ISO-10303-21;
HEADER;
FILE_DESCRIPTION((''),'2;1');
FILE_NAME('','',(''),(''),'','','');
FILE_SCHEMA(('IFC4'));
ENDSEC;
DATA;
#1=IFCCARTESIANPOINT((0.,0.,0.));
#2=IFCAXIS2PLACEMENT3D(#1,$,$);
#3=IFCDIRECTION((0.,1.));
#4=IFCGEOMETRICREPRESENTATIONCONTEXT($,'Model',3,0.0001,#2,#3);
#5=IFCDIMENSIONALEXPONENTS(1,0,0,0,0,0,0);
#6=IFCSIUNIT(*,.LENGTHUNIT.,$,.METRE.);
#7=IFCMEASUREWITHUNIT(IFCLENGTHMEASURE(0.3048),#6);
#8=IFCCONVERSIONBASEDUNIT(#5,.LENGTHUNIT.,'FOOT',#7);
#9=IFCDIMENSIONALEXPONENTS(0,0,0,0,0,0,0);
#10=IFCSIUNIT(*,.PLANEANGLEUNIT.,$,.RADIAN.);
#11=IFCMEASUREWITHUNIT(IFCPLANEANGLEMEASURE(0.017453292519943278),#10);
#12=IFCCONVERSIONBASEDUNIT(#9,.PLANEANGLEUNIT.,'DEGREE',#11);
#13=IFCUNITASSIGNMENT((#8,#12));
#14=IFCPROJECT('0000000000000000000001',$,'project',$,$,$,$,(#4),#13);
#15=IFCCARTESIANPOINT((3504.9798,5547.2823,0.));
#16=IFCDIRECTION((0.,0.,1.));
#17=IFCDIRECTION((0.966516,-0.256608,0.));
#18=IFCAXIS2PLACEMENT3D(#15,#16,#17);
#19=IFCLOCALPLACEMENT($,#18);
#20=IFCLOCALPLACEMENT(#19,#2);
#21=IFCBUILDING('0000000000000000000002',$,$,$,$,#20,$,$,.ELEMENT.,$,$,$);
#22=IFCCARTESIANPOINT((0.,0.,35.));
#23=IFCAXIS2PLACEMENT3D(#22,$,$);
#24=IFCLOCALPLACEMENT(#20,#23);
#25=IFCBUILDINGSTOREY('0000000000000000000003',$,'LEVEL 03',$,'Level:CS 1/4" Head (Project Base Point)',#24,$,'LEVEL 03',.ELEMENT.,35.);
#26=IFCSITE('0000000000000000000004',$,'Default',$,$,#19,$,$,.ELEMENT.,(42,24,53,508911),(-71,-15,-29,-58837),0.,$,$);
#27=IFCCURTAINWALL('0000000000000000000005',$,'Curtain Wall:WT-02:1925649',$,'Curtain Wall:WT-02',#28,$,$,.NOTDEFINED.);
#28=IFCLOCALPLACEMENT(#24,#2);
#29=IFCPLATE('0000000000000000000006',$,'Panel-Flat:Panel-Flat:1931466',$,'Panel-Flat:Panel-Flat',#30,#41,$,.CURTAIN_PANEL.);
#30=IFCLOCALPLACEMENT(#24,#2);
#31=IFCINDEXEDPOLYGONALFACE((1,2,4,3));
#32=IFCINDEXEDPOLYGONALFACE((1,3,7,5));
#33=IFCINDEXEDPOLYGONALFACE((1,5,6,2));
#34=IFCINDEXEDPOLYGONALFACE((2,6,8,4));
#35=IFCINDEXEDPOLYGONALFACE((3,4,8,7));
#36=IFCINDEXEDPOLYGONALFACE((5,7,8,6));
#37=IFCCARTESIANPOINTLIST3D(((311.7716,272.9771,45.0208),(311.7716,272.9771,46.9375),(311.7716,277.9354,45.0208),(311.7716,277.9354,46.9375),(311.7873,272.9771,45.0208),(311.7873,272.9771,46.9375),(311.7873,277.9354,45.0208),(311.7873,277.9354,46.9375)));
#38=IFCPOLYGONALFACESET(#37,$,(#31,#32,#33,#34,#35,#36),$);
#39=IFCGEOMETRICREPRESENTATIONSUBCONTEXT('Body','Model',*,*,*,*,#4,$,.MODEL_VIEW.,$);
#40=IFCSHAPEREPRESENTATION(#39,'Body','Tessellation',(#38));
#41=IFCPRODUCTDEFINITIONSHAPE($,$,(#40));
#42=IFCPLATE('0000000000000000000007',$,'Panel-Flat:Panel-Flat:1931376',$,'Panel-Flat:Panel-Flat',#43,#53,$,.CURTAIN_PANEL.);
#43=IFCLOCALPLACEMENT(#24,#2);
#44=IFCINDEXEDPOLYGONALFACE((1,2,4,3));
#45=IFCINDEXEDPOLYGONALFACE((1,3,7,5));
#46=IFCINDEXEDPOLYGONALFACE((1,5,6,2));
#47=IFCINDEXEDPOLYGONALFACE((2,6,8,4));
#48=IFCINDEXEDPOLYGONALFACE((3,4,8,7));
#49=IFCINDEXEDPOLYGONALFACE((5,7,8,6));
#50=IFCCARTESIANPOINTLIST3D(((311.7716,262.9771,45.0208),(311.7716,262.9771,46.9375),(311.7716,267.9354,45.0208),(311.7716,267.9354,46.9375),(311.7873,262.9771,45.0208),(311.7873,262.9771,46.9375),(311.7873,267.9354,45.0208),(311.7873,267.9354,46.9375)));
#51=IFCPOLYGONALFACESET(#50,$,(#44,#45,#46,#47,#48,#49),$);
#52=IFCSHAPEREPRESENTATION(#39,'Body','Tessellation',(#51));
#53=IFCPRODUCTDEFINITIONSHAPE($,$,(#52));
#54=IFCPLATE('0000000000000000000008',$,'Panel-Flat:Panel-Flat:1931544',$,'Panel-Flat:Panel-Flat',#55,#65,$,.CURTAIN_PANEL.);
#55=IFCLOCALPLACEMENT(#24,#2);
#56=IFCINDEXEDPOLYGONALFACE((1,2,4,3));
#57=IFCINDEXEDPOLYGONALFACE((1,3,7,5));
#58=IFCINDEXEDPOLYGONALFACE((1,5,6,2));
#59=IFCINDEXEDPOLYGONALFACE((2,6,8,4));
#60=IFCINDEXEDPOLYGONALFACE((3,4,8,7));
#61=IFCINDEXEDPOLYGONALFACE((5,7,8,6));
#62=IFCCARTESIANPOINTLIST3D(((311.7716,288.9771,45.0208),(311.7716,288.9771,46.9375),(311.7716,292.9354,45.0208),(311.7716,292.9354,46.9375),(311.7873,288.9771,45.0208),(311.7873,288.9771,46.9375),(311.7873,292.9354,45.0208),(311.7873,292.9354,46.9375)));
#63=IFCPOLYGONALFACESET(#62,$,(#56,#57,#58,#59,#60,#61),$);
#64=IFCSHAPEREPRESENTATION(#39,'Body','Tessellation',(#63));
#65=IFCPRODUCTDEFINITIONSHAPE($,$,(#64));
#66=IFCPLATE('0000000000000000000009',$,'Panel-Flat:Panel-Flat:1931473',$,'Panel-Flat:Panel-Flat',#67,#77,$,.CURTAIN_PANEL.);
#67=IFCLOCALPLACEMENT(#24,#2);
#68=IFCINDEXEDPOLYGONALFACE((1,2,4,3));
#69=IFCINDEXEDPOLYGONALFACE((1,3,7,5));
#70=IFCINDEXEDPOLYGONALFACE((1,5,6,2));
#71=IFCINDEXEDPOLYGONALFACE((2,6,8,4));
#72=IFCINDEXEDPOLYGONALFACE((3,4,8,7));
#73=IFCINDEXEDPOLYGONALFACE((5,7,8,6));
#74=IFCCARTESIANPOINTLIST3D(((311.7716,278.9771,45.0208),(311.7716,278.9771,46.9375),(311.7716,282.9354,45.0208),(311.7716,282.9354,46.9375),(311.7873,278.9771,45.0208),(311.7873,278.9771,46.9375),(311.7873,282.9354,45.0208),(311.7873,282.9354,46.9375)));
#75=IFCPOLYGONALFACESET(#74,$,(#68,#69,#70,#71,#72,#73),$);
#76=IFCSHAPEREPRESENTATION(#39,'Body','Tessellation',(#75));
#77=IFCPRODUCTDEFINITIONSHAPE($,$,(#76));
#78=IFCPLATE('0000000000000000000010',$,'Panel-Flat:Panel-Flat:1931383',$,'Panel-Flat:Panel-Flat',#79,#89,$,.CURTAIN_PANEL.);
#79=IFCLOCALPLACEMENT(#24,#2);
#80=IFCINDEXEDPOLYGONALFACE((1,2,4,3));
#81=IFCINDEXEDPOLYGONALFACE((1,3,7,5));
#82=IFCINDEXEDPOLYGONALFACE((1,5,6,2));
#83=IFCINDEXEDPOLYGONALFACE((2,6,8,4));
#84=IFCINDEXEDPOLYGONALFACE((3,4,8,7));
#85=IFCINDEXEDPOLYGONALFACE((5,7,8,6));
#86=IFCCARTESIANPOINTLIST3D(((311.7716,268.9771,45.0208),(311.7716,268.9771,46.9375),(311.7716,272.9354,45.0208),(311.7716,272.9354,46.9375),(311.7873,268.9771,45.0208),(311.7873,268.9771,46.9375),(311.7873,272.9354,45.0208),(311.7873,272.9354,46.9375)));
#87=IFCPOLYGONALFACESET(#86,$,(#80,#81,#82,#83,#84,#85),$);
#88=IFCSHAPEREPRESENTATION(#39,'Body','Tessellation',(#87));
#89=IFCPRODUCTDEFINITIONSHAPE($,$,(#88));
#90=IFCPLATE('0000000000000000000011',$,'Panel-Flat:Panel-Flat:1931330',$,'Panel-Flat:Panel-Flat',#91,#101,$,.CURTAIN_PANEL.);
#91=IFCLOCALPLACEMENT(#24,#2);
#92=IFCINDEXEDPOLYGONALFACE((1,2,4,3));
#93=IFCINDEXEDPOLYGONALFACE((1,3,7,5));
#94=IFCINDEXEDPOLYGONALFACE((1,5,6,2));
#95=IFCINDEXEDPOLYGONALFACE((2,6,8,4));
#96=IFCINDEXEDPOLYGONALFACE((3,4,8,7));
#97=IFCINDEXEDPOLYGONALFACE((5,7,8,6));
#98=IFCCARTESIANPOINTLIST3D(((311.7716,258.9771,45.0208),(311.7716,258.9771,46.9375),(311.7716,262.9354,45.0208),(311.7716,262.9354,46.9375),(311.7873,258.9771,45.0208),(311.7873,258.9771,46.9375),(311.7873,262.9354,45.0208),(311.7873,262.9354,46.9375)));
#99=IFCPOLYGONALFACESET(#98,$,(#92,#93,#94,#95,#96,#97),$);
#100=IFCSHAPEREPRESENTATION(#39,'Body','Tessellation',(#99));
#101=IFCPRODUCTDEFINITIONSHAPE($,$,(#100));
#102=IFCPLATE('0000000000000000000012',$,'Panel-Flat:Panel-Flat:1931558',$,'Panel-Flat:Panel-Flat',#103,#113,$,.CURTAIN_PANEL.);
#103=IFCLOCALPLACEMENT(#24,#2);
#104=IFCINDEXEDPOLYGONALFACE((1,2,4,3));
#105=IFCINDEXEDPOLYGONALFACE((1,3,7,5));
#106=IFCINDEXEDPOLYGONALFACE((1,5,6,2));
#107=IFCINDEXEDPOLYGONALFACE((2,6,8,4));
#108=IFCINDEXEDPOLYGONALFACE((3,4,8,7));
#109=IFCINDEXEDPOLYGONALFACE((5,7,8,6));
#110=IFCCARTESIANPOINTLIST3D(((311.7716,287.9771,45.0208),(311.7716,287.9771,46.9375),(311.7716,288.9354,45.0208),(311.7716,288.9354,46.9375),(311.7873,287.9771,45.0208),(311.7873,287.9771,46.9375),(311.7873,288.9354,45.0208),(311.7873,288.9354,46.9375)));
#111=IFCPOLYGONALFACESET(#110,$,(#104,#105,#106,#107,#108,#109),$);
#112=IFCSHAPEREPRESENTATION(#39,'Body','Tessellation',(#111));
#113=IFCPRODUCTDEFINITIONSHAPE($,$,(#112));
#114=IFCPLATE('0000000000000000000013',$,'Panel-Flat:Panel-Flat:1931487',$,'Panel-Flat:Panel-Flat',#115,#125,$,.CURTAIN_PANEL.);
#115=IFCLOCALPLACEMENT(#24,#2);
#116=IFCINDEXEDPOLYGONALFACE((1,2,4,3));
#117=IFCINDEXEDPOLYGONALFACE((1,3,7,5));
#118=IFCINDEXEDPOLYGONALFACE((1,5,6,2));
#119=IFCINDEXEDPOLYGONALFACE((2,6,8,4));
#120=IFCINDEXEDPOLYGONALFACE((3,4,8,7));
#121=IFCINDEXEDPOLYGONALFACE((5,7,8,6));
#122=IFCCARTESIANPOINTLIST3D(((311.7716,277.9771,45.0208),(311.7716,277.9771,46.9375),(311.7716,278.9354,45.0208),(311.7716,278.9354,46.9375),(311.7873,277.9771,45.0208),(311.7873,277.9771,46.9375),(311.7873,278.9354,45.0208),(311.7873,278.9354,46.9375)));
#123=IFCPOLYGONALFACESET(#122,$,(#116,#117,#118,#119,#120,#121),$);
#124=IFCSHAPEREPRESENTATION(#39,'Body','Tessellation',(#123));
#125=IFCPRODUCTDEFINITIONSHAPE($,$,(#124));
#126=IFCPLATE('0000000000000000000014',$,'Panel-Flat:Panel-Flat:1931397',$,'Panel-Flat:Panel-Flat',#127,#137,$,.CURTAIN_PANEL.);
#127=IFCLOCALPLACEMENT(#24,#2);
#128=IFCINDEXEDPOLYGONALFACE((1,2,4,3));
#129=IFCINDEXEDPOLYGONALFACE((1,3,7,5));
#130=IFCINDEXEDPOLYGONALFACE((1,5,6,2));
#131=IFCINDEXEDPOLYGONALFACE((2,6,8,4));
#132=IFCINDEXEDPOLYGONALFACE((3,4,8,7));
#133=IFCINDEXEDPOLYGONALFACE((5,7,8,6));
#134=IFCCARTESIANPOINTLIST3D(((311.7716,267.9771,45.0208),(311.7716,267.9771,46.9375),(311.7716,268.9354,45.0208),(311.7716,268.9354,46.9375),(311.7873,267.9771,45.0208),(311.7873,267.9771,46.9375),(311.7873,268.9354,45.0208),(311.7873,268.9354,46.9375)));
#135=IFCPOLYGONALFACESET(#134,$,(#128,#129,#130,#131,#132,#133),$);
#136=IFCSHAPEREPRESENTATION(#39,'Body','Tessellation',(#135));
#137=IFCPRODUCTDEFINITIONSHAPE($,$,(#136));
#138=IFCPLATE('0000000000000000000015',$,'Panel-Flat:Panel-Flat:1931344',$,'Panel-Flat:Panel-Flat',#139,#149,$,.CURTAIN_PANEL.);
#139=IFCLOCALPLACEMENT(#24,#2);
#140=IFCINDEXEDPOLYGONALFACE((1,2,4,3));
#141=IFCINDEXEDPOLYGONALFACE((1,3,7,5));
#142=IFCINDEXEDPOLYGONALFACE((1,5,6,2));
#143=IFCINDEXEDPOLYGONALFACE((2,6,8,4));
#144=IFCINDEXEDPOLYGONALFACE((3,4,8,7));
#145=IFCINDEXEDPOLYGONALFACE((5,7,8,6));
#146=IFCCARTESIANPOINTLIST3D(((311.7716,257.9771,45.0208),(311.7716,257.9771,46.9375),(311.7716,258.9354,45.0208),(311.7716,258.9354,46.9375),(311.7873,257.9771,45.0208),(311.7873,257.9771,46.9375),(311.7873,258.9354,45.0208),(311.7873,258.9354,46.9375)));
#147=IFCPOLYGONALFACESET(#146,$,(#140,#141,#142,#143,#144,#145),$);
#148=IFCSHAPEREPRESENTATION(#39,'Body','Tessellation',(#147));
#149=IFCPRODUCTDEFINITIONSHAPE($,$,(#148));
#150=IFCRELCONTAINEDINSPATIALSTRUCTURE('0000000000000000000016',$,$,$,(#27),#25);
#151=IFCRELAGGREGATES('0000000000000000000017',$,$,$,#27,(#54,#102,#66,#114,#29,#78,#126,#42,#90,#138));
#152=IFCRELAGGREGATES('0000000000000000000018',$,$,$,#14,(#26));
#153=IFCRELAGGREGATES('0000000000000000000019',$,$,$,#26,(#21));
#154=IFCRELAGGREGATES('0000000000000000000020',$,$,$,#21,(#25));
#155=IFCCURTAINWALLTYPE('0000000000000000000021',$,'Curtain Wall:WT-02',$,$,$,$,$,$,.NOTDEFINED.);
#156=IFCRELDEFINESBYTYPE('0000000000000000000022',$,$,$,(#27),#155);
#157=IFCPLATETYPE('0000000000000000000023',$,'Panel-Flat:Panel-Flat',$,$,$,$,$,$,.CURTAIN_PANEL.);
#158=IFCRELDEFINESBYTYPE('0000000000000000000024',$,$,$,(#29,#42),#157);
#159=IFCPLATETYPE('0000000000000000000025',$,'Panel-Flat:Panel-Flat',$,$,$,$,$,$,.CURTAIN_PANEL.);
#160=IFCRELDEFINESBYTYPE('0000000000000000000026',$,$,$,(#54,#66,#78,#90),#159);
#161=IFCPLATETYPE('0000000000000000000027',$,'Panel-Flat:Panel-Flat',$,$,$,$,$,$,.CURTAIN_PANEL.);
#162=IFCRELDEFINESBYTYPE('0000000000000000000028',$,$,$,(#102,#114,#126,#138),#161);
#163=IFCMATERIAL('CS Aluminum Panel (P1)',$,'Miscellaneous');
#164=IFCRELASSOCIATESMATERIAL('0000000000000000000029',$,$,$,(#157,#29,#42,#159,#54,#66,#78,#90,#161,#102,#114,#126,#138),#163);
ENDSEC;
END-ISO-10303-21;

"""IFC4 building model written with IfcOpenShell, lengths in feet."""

from ifc_helpers import new_model, entity, si_unit, converted_unit, direction, frame, origin, place, context, subcontext, project, spatial, indexed_curve, outline, extrude, source, transform, mapped, material, type_object, type_shapes, element, aggregate, save


model = new_model("IFC4")

# Units and contexts
model_context = context("Model", 3, precision=0.0001, world=origin(), true_north=direction((0.0, 1.0)))
body_context = subcontext(model_context, "Body", "Model", "MODEL_VIEW")
ifc_project = project(units=[converted_unit("LENGTHUNIT", "FOOT", entity("IfcLengthMeasure", 0.3048), si_unit("LENGTHUNIT", "METRE"), dimensions=[1, 0, 0, 0, 0, 0, 0]), converted_unit("PLANEANGLEUNIT", "DEGREE", entity("IfcPlaneAngleMeasure", 0.017453292519943278), si_unit("PLANEANGLEUNIT", "RADIAN"), dimensions=[0, 0, 0, 0, 0, 0, 0])], contexts=[model_context])

# Site, building, storey
site_placement = place(None, frame((3504.9798, 5547.2823, 0.0), z_axis=(0.0, 0.0, 1.0), x_axis=(0.966516, -0.256608, 0.0)))
site = spatial("IfcSite", under=ifc_project, at=site_placement, Name="Default", CompositionType="ELEMENT", RefLatitude=(42, 24, 53, 508911), RefLongitude=(-71, -15, -29, -58837), RefElevation=0.0)
building_placement = place(site_placement, origin())
building = spatial("IfcBuilding", under=site, at=building_placement, CompositionType="ELEMENT")
storey_placement = place(building_placement, frame((0.0, 0.0, 35.0)))
storey = spatial("IfcBuildingStorey", under=building, at=storey_placement, Name="LEVEL 03", ObjectType="Level:CS 1/4\" Head (Project Base Point)", LongName="LEVEL 03", CompositionType="ELEMENT", Elevation=35.0)

# Curtain wall, plates
curtain_wall_type = type_object("IfcCurtainWallType", Name="Curtain Wall:WT-02", PredefinedType="NOTDEFINED")
curtain_wall_placement = place(storey_placement, frame((0.0, 0.0, -35.0)))
curtain_wall = element("IfcCurtainWall", 1, at=curtain_wall_placement, inside=storey, type_object=curtain_wall_type, Name="Curtain Wall:WT-02:1925649", ObjectType="Curtain Wall:WT-02", PredefinedType="NOTDEFINED")
ifc_material = material(Name="CS Aluminum Panel (P1)", Category="Miscellaneous")
plate_type_1 = type_object("IfcPlateType", Name="Panel-Flat:Panel-Flat", PredefinedType="CURTAIN_PANEL", material=ifc_material)
shared_shape_1 = source(origin(), body_context, "Body", "SweptSolid", [
    extrude(outline(indexed_curve([(-0.0078, -2.4792), (0.0078, -2.4792), (0.0078, 2.4792), (-0.0078, 2.4792), (-0.0078, -2.4792)], self_intersect=False)), frame((0.0, -0.0078, 0.0208), z_axis=(0.0, 0.0, 1.0), x_axis=(0.0, -1.0, 0.0)), (0.0, 0.0, 1.0), 1.9167),
])
type_shapes(plate_type_1, [shared_shape_1])
plate_1_placement = place(curtain_wall_placement, frame((311.7873, 275.4563, 80.0), z_axis=(0.0, 0.0, 1.0), x_axis=(0.0, -1.0, 0.0)))
plate_1 = element("IfcPlate", 2, at=plate_1_placement, type_object=plate_type_1, material=ifc_material, Name="Panel-Flat:Panel-Flat:1931466", ObjectType="Panel-Flat:Panel-Flat", PredefinedType="CURTAIN_PANEL", context=body_context, shape_type="MappedRepresentation", body=[
    mapped(shared_shape_1, transform((0.0, 0.0, 0.0), scale=1.0)),
])
plate_2_placement = place(curtain_wall_placement, frame((311.7873, 265.4563, 80.0), z_axis=(0.0, 0.0, 1.0), x_axis=(0.0, -1.0, 0.0)))
plate_2 = element("IfcPlate", 3, at=plate_2_placement, type_object=plate_type_1, material=ifc_material, Name="Panel-Flat:Panel-Flat:1931376", ObjectType="Panel-Flat:Panel-Flat", PredefinedType="CURTAIN_PANEL", context=body_context, shape_type="MappedRepresentation", body=[
    mapped(shared_shape_1, transform((0.0, 0.0, 0.0), scale=1.0)),
])
plate_type_2 = type_object("IfcPlateType", Name="Panel-Flat:Panel-Flat", PredefinedType="CURTAIN_PANEL", material=ifc_material)
shared_shape_2 = source(origin(), body_context, "Body", "SweptSolid", [
    extrude(outline(indexed_curve([(-0.0078, -1.9792), (0.0078, -1.9792), (0.0078, 1.9792), (-0.0078, 1.9792), (-0.0078, -1.9792)], self_intersect=False)), frame((0.0, -0.0078, 0.0208), z_axis=(0.0, 0.0, 1.0), x_axis=(0.0, -1.0, 0.0)), (0.0, 0.0, 1.0), 1.9167),
])
type_shapes(plate_type_2, [shared_shape_2])
plate_3_placement = place(curtain_wall_placement, frame((311.7873, 290.9563, 80.0), z_axis=(0.0, 0.0, 1.0), x_axis=(0.0, -1.0, 0.0)))
plate_3 = element("IfcPlate", 4, at=plate_3_placement, type_object=plate_type_2, material=ifc_material, Name="Panel-Flat:Panel-Flat:1931544", ObjectType="Panel-Flat:Panel-Flat", PredefinedType="CURTAIN_PANEL", context=body_context, shape_type="MappedRepresentation", body=[
    mapped(shared_shape_2, transform((0.0, 0.0, 0.0), scale=1.0)),
])
plate_4_placement = place(curtain_wall_placement, frame((311.7873, 280.9563, 80.0), z_axis=(0.0, 0.0, 1.0), x_axis=(0.0, -1.0, 0.0)))
plate_4 = element("IfcPlate", 5, at=plate_4_placement, type_object=plate_type_2, material=ifc_material, Name="Panel-Flat:Panel-Flat:1931473", ObjectType="Panel-Flat:Panel-Flat", PredefinedType="CURTAIN_PANEL", context=body_context, shape_type="MappedRepresentation", body=[
    mapped(shared_shape_2, transform((0.0, 0.0, 0.0), scale=1.0)),
])
plate_5_placement = place(curtain_wall_placement, frame((311.7873, 270.9563, 80.0), z_axis=(0.0, 0.0, 1.0), x_axis=(0.0, -1.0, 0.0)))
plate_5 = element("IfcPlate", 6, at=plate_5_placement, type_object=plate_type_2, material=ifc_material, Name="Panel-Flat:Panel-Flat:1931383", ObjectType="Panel-Flat:Panel-Flat", PredefinedType="CURTAIN_PANEL", context=body_context, shape_type="MappedRepresentation", body=[
    mapped(shared_shape_2, transform((0.0, 0.0, 0.0), scale=1.0)),
])
plate_6_placement = place(curtain_wall_placement, frame((311.7873, 260.9563, 80.0), z_axis=(0.0, 0.0, 1.0), x_axis=(0.0, -1.0, 0.0)))
plate_6 = element("IfcPlate", 7, at=plate_6_placement, type_object=plate_type_2, material=ifc_material, Name="Panel-Flat:Panel-Flat:1931330", ObjectType="Panel-Flat:Panel-Flat", PredefinedType="CURTAIN_PANEL", context=body_context, shape_type="MappedRepresentation", body=[
    mapped(shared_shape_2, transform((0.0, 0.0, 0.0), scale=1.0)),
])
plate_type_3 = type_object("IfcPlateType", Name="Panel-Flat:Panel-Flat", PredefinedType="CURTAIN_PANEL", material=ifc_material)
shared_shape_3 = source(origin(), body_context, "Body", "SweptSolid", [
    extrude(outline(indexed_curve([(-0.0078, -0.4792), (0.0078, -0.4792), (0.0078, 0.4792), (-0.0078, 0.4792), (-0.0078, -0.4792)], self_intersect=False)), frame((0.0, -0.0078, 0.0208), z_axis=(0.0, 0.0, 1.0), x_axis=(0.0, -1.0, 0.0)), (0.0, 0.0, 1.0), 1.9167),
])
type_shapes(plate_type_3, [shared_shape_3])
plate_7_placement = place(curtain_wall_placement, frame((311.7873, 288.4563, 80.0), z_axis=(0.0, 0.0, 1.0), x_axis=(0.0, -1.0, 0.0)))
plate_7 = element("IfcPlate", 8, at=plate_7_placement, type_object=plate_type_3, material=ifc_material, Name="Panel-Flat:Panel-Flat:1931558", ObjectType="Panel-Flat:Panel-Flat", PredefinedType="CURTAIN_PANEL", context=body_context, shape_type="MappedRepresentation", body=[
    mapped(shared_shape_3, transform((0.0, 0.0, 0.0), scale=1.0)),
])
plate_8_placement = place(curtain_wall_placement, frame((311.7873, 278.4563, 80.0), z_axis=(0.0, 0.0, 1.0), x_axis=(0.0, -1.0, 0.0)))
plate_8 = element("IfcPlate", 9, at=plate_8_placement, type_object=plate_type_3, material=ifc_material, Name="Panel-Flat:Panel-Flat:1931487", ObjectType="Panel-Flat:Panel-Flat", PredefinedType="CURTAIN_PANEL", context=body_context, shape_type="MappedRepresentation", body=[
    mapped(shared_shape_3, transform((0.0, 0.0, 0.0), scale=1.0)),
])
plate_9_placement = place(curtain_wall_placement, frame((311.7873, 268.4563, 80.0), z_axis=(0.0, 0.0, 1.0), x_axis=(0.0, -1.0, 0.0)))
plate_9 = element("IfcPlate", 10, at=plate_9_placement, type_object=plate_type_3, material=ifc_material, Name="Panel-Flat:Panel-Flat:1931397", ObjectType="Panel-Flat:Panel-Flat", PredefinedType="CURTAIN_PANEL", context=body_context, shape_type="MappedRepresentation", body=[
    mapped(shared_shape_3, transform((0.0, 0.0, 0.0), scale=1.0)),
])
plate_10_placement = place(curtain_wall_placement, frame((311.7873, 258.4563, 80.0), z_axis=(0.0, 0.0, 1.0), x_axis=(0.0, -1.0, 0.0)))
plate_10 = element("IfcPlate", 11, at=plate_10_placement, type_object=plate_type_3, material=ifc_material, Name="Panel-Flat:Panel-Flat:1931344", ObjectType="Panel-Flat:Panel-Flat", PredefinedType="CURTAIN_PANEL", context=body_context, shape_type="MappedRepresentation", body=[
    mapped(shared_shape_3, transform((0.0, 0.0, 0.0), scale=1.0)),
])
aggregate(curtain_wall, [plate_3, plate_7, plate_4, plate_8, plate_1, plate_5, plate_9, plate_2, plate_6, plate_10])

save(model, "model.ifc")
